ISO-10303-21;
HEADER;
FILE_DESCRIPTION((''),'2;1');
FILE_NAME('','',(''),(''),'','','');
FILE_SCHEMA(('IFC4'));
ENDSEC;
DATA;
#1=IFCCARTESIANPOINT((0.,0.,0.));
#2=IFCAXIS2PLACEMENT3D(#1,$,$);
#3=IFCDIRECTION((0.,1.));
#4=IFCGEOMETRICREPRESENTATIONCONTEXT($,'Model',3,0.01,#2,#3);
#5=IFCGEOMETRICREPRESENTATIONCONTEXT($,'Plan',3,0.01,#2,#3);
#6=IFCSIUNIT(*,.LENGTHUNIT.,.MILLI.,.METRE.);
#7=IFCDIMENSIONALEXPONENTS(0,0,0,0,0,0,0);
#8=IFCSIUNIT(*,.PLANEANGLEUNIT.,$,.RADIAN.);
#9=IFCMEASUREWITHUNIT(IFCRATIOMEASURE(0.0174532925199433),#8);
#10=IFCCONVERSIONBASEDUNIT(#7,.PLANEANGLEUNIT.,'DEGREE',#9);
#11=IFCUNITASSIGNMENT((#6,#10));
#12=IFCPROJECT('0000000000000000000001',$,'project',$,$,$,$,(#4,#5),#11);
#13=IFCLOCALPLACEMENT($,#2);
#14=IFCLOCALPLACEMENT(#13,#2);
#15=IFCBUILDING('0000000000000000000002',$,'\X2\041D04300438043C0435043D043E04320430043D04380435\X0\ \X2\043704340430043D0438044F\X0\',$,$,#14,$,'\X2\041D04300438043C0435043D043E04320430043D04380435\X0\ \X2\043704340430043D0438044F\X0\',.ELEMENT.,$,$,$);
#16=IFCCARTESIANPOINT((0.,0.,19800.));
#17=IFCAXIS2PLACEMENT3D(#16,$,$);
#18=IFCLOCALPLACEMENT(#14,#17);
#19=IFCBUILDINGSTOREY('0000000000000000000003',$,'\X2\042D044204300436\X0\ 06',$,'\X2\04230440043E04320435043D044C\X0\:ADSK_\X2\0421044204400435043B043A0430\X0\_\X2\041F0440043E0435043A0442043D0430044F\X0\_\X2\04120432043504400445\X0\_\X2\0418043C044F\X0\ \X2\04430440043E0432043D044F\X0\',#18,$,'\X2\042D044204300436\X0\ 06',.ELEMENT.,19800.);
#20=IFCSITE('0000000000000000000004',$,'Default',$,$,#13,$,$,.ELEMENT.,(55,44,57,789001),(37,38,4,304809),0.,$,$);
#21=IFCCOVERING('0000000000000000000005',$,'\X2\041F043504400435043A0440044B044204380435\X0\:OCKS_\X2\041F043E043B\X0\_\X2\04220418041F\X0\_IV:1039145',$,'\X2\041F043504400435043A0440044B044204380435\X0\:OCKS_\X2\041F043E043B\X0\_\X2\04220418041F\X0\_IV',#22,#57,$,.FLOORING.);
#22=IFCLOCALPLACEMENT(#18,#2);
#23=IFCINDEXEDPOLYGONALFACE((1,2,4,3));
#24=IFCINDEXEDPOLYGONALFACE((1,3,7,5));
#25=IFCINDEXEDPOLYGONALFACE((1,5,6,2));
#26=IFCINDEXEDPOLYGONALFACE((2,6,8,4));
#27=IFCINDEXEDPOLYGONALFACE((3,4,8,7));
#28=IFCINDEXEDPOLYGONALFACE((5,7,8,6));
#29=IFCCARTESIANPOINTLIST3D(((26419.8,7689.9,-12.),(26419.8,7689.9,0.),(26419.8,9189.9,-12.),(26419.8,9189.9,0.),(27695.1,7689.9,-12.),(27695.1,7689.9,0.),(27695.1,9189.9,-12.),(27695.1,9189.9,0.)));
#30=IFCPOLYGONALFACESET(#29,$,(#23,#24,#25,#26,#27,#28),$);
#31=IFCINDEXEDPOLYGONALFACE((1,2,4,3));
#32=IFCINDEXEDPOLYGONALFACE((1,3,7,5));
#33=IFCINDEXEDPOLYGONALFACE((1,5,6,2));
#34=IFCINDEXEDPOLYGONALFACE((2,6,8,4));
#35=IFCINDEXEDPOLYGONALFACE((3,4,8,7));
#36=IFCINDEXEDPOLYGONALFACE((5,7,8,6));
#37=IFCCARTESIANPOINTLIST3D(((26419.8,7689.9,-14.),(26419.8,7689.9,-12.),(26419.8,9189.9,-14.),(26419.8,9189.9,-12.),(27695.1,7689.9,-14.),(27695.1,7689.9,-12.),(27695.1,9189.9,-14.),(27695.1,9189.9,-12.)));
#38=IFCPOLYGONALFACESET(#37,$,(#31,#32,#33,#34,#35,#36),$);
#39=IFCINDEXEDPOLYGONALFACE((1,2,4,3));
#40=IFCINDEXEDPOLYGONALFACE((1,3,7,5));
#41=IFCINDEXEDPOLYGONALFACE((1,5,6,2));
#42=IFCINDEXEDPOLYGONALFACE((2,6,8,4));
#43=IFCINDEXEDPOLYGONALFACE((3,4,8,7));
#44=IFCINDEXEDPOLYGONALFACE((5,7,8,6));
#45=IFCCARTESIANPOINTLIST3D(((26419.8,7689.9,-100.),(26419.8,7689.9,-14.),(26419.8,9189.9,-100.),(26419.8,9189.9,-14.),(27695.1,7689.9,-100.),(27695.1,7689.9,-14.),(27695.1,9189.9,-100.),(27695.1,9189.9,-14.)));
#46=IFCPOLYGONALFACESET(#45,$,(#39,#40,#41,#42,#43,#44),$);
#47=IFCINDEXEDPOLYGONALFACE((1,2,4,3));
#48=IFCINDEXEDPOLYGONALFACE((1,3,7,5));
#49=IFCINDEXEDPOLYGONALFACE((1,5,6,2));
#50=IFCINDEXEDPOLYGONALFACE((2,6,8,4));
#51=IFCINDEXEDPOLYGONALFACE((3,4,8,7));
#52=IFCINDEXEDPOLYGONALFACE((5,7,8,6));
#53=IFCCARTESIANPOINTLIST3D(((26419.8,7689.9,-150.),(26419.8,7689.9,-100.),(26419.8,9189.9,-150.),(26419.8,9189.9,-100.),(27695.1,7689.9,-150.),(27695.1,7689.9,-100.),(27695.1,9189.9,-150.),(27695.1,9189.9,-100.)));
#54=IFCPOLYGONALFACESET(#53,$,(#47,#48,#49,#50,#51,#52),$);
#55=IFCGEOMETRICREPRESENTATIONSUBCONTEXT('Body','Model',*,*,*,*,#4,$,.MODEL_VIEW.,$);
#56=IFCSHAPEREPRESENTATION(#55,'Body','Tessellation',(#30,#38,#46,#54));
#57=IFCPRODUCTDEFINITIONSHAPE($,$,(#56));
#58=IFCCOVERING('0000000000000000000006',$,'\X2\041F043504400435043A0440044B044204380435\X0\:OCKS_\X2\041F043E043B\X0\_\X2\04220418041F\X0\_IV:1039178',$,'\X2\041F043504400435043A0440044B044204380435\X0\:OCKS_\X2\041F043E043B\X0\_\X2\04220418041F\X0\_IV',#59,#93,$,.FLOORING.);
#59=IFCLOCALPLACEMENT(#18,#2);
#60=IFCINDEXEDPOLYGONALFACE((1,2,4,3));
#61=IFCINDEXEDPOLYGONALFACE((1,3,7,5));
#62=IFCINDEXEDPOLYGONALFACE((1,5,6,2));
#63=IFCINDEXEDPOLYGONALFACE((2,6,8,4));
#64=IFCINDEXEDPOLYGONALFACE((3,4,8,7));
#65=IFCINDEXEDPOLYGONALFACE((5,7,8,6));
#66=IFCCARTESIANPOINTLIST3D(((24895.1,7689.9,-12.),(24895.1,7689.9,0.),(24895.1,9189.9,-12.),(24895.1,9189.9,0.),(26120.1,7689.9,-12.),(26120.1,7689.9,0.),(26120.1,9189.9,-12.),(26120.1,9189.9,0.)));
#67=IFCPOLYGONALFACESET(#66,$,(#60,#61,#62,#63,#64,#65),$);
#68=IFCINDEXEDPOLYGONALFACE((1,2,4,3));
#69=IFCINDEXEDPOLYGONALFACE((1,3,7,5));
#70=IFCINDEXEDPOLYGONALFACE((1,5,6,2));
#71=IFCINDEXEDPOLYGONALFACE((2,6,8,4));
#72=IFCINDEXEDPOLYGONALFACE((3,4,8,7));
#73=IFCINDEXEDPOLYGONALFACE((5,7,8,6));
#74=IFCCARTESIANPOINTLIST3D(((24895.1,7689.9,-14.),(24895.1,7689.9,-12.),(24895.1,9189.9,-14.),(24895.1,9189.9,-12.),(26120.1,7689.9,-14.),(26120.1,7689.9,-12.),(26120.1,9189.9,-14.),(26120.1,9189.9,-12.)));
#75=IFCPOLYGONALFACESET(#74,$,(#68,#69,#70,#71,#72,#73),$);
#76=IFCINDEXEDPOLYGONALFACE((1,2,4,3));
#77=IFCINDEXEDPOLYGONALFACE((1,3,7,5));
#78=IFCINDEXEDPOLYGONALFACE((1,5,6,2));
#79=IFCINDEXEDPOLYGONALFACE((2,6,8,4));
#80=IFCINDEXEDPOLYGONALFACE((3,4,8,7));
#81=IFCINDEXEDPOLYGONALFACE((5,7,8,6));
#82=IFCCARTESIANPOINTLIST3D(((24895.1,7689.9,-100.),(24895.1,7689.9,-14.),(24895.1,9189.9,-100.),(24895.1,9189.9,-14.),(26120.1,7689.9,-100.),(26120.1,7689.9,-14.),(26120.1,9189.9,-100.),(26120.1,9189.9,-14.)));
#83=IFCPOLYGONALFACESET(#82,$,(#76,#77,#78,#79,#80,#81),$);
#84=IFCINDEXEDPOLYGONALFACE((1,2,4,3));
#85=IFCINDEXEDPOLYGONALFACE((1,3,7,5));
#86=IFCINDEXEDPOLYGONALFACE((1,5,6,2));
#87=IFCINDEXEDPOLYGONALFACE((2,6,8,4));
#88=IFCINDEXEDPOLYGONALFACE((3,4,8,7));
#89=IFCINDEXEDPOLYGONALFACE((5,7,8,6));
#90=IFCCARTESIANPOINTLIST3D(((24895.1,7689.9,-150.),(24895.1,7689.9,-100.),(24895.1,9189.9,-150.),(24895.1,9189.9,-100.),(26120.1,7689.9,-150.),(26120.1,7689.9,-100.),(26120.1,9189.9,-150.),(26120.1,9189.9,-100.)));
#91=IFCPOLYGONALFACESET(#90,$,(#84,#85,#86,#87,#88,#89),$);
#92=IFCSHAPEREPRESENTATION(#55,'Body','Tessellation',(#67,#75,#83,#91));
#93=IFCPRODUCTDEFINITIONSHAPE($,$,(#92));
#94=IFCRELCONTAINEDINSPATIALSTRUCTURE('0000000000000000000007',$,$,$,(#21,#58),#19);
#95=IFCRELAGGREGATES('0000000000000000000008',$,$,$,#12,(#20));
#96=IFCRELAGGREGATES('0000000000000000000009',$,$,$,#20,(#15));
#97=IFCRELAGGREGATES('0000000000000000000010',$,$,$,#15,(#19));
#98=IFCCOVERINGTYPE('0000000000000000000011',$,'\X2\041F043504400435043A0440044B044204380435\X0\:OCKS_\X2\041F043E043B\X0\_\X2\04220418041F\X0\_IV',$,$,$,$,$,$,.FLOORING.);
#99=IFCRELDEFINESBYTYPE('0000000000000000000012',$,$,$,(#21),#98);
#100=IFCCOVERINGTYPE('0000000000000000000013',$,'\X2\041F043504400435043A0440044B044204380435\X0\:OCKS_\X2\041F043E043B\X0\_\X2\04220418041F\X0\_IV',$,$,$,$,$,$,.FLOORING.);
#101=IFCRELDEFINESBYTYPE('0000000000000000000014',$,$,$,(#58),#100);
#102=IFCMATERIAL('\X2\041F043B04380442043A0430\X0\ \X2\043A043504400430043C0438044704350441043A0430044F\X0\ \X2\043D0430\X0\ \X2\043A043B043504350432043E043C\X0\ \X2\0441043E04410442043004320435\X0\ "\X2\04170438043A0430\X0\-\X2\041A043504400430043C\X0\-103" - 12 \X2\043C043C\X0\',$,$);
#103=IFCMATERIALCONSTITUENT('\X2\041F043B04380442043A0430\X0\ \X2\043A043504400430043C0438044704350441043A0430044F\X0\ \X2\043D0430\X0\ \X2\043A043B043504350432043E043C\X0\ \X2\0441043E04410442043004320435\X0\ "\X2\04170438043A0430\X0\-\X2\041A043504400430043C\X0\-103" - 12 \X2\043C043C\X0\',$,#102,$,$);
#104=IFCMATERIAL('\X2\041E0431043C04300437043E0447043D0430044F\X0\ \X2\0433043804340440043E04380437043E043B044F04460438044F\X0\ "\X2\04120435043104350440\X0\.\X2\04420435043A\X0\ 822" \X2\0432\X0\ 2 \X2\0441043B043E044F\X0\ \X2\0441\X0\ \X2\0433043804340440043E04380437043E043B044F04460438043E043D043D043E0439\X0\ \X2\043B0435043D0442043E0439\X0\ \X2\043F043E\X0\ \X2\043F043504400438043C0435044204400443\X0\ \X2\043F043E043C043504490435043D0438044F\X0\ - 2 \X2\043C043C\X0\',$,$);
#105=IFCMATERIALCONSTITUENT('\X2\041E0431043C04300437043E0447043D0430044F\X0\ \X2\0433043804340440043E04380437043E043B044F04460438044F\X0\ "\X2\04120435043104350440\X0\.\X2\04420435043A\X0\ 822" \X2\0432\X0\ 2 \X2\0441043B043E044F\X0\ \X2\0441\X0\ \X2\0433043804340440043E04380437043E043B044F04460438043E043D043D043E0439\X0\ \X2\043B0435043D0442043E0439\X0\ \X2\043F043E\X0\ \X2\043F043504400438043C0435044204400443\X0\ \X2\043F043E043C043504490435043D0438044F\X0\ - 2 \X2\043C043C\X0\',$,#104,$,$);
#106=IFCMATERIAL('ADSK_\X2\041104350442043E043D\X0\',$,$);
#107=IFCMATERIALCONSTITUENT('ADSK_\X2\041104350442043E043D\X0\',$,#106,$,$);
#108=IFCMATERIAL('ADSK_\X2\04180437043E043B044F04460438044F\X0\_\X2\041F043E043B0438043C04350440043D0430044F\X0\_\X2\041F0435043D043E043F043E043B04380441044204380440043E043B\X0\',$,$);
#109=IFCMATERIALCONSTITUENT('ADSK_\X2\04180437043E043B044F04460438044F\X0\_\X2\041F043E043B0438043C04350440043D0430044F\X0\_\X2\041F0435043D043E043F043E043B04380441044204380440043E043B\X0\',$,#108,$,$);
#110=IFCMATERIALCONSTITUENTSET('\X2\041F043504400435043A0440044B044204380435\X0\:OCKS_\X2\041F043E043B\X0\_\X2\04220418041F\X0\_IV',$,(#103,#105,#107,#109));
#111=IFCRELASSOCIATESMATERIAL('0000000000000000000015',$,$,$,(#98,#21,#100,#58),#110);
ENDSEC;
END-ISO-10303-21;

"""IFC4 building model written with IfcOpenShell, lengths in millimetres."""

from ifc_helpers import new_model, entity, si_unit, converted_unit, direction, frame, origin, place, context, subcontext, project, spatial, indexed_curve, outline, extrude, material, constituent, constituent_set, type_object, element, save


model = new_model("IFC4")

# Units and contexts
model_context = context("Model", 3, precision=0.01, world=origin(), true_north=direction((0.0, 1.0)))
plan_context = context("Plan", 3, precision=0.01, world=origin(), true_north=direction((0.0, 1.0)))
body_context = subcontext(model_context, "Body", "Model", "MODEL_VIEW")
ifc_project = project(units=[si_unit("LENGTHUNIT", "METRE", prefix="MILLI"), converted_unit("PLANEANGLEUNIT", "DEGREE", entity("IfcRatioMeasure", 0.0174532925199433), si_unit("PLANEANGLEUNIT", "RADIAN"), dimensions=[0, 0, 0, 0, 0, 0, 0])], contexts=[model_context, plan_context])

# Site, building, storey
site_placement = place(None, frame((0.0, 0.0, 0.0)))
site = spatial("IfcSite", under=ifc_project, at=site_placement, Name="Default", CompositionType="ELEMENT", RefLatitude=(55, 44, 57, 789001), RefLongitude=(37, 38, 4, 304809), RefElevation=0.0)
building_placement = place(site_placement, origin())
building = spatial("IfcBuilding", under=site, at=building_placement, Name="Наименование здания", LongName="Наименование здания", CompositionType="ELEMENT")
storey_placement = place(building_placement, frame((0.0, 0.0, 19800.0)))
storey = spatial("IfcBuildingStorey", under=building, at=storey_placement, Name="Этаж 06", ObjectType="Уровень:ADSK_Стрелка_Проектная_Вверх_Имя уровня", LongName="Этаж 06", CompositionType="ELEMENT", Elevation=19800.0)

# Coverings
ifc_material_1 = material(Name="Обмазочная гидроизоляция \"Вебер.тек 822\" в 2 слоя с гидроизоляционной лентой по периметру помещения - 2 мм")
ifc_material_2 = material(Name="ADSK_Бетон")
ifc_material_3 = material(Name="ADSK_Изоляция_Полимерная_Пенополистирол")
ifc_material_4 = material(Name="Плитка керамическая на клеевом составе \"Зика-Керам-103\" - 12 мм")
ifc_constituent_1 = constituent(ifc_material_4, Name="Плитка керамическая на клеевом составе \"Зика-Керам-103\" - 12 мм")
ifc_constituent_2 = constituent(ifc_material_1, Name="Обмазочная гидроизоляция \"Вебер.тек 822\" в 2 слоя с гидроизоляционной лентой по периметру помещения - 2 мм")
ifc_constituent_3 = constituent(ifc_material_2, Name="ADSK_Бетон")
ifc_constituent_4 = constituent(ifc_material_3, Name="ADSK_Изоляция_Полимерная_Пенополистирол")
ifc_constituent_set_1 = constituent_set(constituents=[ifc_constituent_1, ifc_constituent_2, ifc_constituent_3, ifc_constituent_4], Name="Перекрытие:OCKS_Пол_ТИП_IV")
covering_type_1 = type_object("IfcCoveringType", Name="Перекрытие:OCKS_Пол_ТИП_IV", PredefinedType="FLOORING", material=ifc_constituent_set_1)
covering_1_placement = place(storey_placement, origin())
element("IfcCovering", 1, at=covering_1_placement, inside=storey, type_object=covering_type_1, material=ifc_constituent_set_1, Name="Перекрытие:OCKS_Пол_ТИП_IV:1039145", ObjectType="Перекрытие:OCKS_Пол_ТИП_IV", PredefinedType="FLOORING", context=body_context, shape_type="SweptSolid", body=[
    extrude(outline(indexed_curve([(-637.6, -750.0), (637.6, -750.0), (637.6, 750.0), (-637.6, 750.0), (-637.6, -750.0)], self_intersect=False)), frame((27057.5, 8439.9, -12.0), z_axis=(0.0, 0.0, 1.0), x_axis=(-1.0, 0.0, 0.0)), (0.0, 0.0, 1.0), 12.0),
    extrude(outline(indexed_curve([(-637.6, -750.0), (637.6, -750.0), (637.6, 750.0), (-637.6, 750.0), (-637.6, -750.0)], self_intersect=False)), frame((27057.5, 8439.9, -14.0), z_axis=(0.0, 0.0, 1.0), x_axis=(-1.0, 0.0, 0.0)), (0.0, 0.0, 1.0), 2.0),
    extrude(outline(indexed_curve([(-637.6, -750.0), (637.6, -750.0), (637.6, 750.0), (-637.6, 750.0), (-637.6, -750.0)], self_intersect=False)), frame((27057.5, 8439.9, -100.0), z_axis=(0.0, 0.0, 1.0), x_axis=(-1.0, 0.0, 0.0)), (0.0, 0.0, 1.0), 86.0),
    extrude(outline(indexed_curve([(-637.6, -750.0), (637.6, -750.0), (637.6, 750.0), (-637.6, 750.0), (-637.6, -750.0)], self_intersect=False)), frame((27057.5, 8439.9, -150.0), z_axis=(0.0, 0.0, 1.0), x_axis=(-1.0, 0.0, 0.0)), (0.0, 0.0, 1.0), 50.0),
])
covering_type_2 = type_object("IfcCoveringType", Name="Перекрытие:OCKS_Пол_ТИП_IV", PredefinedType="FLOORING", material=ifc_constituent_set_1)
covering_2_placement = place(storey_placement, origin())
element("IfcCovering", 2, at=covering_2_placement, inside=storey, type_object=covering_type_2, material=ifc_constituent_set_1, Name="Перекрытие:OCKS_Пол_ТИП_IV:1039178", ObjectType="Перекрытие:OCKS_Пол_ТИП_IV", PredefinedType="FLOORING", context=body_context, shape_type="SweptSolid", body=[
    extrude(outline(indexed_curve([(-612.5, -750.0), (612.5, -750.0), (612.5, 750.0), (-612.5, 750.0), (-612.5, -750.0)], self_intersect=False)), frame((25507.6, 8439.9, -12.0), z_axis=(0.0, 0.0, 1.0), x_axis=(-1.0, 0.0, 0.0)), (0.0, 0.0, 1.0), 12.0),
    extrude(outline(indexed_curve([(-612.5, -750.0), (612.5, -750.0), (612.5, 750.0), (-612.5, 750.0), (-612.5, -750.0)], self_intersect=False)), frame((25507.6, 8439.9, -14.0), z_axis=(0.0, 0.0, 1.0), x_axis=(-1.0, 0.0, 0.0)), (0.0, 0.0, 1.0), 2.0),
    extrude(outline(indexed_curve([(-612.5, -750.0), (612.5, -750.0), (612.5, 750.0), (-612.5, 750.0), (-612.5, -750.0)], self_intersect=False)), frame((25507.6, 8439.9, -100.0), z_axis=(0.0, 0.0, 1.0), x_axis=(-1.0, 0.0, 0.0)), (0.0, 0.0, 1.0), 86.0),
    extrude(outline(indexed_curve([(-612.5, -750.0), (612.5, -750.0), (612.5, 750.0), (-612.5, 750.0), (-612.5, -750.0)], self_intersect=False)), frame((25507.6, 8439.9, -150.0), z_axis=(0.0, 0.0, 1.0), x_axis=(-1.0, 0.0, 0.0)), (0.0, 0.0, 1.0), 50.0),
])

save(model, "model.ifc")
